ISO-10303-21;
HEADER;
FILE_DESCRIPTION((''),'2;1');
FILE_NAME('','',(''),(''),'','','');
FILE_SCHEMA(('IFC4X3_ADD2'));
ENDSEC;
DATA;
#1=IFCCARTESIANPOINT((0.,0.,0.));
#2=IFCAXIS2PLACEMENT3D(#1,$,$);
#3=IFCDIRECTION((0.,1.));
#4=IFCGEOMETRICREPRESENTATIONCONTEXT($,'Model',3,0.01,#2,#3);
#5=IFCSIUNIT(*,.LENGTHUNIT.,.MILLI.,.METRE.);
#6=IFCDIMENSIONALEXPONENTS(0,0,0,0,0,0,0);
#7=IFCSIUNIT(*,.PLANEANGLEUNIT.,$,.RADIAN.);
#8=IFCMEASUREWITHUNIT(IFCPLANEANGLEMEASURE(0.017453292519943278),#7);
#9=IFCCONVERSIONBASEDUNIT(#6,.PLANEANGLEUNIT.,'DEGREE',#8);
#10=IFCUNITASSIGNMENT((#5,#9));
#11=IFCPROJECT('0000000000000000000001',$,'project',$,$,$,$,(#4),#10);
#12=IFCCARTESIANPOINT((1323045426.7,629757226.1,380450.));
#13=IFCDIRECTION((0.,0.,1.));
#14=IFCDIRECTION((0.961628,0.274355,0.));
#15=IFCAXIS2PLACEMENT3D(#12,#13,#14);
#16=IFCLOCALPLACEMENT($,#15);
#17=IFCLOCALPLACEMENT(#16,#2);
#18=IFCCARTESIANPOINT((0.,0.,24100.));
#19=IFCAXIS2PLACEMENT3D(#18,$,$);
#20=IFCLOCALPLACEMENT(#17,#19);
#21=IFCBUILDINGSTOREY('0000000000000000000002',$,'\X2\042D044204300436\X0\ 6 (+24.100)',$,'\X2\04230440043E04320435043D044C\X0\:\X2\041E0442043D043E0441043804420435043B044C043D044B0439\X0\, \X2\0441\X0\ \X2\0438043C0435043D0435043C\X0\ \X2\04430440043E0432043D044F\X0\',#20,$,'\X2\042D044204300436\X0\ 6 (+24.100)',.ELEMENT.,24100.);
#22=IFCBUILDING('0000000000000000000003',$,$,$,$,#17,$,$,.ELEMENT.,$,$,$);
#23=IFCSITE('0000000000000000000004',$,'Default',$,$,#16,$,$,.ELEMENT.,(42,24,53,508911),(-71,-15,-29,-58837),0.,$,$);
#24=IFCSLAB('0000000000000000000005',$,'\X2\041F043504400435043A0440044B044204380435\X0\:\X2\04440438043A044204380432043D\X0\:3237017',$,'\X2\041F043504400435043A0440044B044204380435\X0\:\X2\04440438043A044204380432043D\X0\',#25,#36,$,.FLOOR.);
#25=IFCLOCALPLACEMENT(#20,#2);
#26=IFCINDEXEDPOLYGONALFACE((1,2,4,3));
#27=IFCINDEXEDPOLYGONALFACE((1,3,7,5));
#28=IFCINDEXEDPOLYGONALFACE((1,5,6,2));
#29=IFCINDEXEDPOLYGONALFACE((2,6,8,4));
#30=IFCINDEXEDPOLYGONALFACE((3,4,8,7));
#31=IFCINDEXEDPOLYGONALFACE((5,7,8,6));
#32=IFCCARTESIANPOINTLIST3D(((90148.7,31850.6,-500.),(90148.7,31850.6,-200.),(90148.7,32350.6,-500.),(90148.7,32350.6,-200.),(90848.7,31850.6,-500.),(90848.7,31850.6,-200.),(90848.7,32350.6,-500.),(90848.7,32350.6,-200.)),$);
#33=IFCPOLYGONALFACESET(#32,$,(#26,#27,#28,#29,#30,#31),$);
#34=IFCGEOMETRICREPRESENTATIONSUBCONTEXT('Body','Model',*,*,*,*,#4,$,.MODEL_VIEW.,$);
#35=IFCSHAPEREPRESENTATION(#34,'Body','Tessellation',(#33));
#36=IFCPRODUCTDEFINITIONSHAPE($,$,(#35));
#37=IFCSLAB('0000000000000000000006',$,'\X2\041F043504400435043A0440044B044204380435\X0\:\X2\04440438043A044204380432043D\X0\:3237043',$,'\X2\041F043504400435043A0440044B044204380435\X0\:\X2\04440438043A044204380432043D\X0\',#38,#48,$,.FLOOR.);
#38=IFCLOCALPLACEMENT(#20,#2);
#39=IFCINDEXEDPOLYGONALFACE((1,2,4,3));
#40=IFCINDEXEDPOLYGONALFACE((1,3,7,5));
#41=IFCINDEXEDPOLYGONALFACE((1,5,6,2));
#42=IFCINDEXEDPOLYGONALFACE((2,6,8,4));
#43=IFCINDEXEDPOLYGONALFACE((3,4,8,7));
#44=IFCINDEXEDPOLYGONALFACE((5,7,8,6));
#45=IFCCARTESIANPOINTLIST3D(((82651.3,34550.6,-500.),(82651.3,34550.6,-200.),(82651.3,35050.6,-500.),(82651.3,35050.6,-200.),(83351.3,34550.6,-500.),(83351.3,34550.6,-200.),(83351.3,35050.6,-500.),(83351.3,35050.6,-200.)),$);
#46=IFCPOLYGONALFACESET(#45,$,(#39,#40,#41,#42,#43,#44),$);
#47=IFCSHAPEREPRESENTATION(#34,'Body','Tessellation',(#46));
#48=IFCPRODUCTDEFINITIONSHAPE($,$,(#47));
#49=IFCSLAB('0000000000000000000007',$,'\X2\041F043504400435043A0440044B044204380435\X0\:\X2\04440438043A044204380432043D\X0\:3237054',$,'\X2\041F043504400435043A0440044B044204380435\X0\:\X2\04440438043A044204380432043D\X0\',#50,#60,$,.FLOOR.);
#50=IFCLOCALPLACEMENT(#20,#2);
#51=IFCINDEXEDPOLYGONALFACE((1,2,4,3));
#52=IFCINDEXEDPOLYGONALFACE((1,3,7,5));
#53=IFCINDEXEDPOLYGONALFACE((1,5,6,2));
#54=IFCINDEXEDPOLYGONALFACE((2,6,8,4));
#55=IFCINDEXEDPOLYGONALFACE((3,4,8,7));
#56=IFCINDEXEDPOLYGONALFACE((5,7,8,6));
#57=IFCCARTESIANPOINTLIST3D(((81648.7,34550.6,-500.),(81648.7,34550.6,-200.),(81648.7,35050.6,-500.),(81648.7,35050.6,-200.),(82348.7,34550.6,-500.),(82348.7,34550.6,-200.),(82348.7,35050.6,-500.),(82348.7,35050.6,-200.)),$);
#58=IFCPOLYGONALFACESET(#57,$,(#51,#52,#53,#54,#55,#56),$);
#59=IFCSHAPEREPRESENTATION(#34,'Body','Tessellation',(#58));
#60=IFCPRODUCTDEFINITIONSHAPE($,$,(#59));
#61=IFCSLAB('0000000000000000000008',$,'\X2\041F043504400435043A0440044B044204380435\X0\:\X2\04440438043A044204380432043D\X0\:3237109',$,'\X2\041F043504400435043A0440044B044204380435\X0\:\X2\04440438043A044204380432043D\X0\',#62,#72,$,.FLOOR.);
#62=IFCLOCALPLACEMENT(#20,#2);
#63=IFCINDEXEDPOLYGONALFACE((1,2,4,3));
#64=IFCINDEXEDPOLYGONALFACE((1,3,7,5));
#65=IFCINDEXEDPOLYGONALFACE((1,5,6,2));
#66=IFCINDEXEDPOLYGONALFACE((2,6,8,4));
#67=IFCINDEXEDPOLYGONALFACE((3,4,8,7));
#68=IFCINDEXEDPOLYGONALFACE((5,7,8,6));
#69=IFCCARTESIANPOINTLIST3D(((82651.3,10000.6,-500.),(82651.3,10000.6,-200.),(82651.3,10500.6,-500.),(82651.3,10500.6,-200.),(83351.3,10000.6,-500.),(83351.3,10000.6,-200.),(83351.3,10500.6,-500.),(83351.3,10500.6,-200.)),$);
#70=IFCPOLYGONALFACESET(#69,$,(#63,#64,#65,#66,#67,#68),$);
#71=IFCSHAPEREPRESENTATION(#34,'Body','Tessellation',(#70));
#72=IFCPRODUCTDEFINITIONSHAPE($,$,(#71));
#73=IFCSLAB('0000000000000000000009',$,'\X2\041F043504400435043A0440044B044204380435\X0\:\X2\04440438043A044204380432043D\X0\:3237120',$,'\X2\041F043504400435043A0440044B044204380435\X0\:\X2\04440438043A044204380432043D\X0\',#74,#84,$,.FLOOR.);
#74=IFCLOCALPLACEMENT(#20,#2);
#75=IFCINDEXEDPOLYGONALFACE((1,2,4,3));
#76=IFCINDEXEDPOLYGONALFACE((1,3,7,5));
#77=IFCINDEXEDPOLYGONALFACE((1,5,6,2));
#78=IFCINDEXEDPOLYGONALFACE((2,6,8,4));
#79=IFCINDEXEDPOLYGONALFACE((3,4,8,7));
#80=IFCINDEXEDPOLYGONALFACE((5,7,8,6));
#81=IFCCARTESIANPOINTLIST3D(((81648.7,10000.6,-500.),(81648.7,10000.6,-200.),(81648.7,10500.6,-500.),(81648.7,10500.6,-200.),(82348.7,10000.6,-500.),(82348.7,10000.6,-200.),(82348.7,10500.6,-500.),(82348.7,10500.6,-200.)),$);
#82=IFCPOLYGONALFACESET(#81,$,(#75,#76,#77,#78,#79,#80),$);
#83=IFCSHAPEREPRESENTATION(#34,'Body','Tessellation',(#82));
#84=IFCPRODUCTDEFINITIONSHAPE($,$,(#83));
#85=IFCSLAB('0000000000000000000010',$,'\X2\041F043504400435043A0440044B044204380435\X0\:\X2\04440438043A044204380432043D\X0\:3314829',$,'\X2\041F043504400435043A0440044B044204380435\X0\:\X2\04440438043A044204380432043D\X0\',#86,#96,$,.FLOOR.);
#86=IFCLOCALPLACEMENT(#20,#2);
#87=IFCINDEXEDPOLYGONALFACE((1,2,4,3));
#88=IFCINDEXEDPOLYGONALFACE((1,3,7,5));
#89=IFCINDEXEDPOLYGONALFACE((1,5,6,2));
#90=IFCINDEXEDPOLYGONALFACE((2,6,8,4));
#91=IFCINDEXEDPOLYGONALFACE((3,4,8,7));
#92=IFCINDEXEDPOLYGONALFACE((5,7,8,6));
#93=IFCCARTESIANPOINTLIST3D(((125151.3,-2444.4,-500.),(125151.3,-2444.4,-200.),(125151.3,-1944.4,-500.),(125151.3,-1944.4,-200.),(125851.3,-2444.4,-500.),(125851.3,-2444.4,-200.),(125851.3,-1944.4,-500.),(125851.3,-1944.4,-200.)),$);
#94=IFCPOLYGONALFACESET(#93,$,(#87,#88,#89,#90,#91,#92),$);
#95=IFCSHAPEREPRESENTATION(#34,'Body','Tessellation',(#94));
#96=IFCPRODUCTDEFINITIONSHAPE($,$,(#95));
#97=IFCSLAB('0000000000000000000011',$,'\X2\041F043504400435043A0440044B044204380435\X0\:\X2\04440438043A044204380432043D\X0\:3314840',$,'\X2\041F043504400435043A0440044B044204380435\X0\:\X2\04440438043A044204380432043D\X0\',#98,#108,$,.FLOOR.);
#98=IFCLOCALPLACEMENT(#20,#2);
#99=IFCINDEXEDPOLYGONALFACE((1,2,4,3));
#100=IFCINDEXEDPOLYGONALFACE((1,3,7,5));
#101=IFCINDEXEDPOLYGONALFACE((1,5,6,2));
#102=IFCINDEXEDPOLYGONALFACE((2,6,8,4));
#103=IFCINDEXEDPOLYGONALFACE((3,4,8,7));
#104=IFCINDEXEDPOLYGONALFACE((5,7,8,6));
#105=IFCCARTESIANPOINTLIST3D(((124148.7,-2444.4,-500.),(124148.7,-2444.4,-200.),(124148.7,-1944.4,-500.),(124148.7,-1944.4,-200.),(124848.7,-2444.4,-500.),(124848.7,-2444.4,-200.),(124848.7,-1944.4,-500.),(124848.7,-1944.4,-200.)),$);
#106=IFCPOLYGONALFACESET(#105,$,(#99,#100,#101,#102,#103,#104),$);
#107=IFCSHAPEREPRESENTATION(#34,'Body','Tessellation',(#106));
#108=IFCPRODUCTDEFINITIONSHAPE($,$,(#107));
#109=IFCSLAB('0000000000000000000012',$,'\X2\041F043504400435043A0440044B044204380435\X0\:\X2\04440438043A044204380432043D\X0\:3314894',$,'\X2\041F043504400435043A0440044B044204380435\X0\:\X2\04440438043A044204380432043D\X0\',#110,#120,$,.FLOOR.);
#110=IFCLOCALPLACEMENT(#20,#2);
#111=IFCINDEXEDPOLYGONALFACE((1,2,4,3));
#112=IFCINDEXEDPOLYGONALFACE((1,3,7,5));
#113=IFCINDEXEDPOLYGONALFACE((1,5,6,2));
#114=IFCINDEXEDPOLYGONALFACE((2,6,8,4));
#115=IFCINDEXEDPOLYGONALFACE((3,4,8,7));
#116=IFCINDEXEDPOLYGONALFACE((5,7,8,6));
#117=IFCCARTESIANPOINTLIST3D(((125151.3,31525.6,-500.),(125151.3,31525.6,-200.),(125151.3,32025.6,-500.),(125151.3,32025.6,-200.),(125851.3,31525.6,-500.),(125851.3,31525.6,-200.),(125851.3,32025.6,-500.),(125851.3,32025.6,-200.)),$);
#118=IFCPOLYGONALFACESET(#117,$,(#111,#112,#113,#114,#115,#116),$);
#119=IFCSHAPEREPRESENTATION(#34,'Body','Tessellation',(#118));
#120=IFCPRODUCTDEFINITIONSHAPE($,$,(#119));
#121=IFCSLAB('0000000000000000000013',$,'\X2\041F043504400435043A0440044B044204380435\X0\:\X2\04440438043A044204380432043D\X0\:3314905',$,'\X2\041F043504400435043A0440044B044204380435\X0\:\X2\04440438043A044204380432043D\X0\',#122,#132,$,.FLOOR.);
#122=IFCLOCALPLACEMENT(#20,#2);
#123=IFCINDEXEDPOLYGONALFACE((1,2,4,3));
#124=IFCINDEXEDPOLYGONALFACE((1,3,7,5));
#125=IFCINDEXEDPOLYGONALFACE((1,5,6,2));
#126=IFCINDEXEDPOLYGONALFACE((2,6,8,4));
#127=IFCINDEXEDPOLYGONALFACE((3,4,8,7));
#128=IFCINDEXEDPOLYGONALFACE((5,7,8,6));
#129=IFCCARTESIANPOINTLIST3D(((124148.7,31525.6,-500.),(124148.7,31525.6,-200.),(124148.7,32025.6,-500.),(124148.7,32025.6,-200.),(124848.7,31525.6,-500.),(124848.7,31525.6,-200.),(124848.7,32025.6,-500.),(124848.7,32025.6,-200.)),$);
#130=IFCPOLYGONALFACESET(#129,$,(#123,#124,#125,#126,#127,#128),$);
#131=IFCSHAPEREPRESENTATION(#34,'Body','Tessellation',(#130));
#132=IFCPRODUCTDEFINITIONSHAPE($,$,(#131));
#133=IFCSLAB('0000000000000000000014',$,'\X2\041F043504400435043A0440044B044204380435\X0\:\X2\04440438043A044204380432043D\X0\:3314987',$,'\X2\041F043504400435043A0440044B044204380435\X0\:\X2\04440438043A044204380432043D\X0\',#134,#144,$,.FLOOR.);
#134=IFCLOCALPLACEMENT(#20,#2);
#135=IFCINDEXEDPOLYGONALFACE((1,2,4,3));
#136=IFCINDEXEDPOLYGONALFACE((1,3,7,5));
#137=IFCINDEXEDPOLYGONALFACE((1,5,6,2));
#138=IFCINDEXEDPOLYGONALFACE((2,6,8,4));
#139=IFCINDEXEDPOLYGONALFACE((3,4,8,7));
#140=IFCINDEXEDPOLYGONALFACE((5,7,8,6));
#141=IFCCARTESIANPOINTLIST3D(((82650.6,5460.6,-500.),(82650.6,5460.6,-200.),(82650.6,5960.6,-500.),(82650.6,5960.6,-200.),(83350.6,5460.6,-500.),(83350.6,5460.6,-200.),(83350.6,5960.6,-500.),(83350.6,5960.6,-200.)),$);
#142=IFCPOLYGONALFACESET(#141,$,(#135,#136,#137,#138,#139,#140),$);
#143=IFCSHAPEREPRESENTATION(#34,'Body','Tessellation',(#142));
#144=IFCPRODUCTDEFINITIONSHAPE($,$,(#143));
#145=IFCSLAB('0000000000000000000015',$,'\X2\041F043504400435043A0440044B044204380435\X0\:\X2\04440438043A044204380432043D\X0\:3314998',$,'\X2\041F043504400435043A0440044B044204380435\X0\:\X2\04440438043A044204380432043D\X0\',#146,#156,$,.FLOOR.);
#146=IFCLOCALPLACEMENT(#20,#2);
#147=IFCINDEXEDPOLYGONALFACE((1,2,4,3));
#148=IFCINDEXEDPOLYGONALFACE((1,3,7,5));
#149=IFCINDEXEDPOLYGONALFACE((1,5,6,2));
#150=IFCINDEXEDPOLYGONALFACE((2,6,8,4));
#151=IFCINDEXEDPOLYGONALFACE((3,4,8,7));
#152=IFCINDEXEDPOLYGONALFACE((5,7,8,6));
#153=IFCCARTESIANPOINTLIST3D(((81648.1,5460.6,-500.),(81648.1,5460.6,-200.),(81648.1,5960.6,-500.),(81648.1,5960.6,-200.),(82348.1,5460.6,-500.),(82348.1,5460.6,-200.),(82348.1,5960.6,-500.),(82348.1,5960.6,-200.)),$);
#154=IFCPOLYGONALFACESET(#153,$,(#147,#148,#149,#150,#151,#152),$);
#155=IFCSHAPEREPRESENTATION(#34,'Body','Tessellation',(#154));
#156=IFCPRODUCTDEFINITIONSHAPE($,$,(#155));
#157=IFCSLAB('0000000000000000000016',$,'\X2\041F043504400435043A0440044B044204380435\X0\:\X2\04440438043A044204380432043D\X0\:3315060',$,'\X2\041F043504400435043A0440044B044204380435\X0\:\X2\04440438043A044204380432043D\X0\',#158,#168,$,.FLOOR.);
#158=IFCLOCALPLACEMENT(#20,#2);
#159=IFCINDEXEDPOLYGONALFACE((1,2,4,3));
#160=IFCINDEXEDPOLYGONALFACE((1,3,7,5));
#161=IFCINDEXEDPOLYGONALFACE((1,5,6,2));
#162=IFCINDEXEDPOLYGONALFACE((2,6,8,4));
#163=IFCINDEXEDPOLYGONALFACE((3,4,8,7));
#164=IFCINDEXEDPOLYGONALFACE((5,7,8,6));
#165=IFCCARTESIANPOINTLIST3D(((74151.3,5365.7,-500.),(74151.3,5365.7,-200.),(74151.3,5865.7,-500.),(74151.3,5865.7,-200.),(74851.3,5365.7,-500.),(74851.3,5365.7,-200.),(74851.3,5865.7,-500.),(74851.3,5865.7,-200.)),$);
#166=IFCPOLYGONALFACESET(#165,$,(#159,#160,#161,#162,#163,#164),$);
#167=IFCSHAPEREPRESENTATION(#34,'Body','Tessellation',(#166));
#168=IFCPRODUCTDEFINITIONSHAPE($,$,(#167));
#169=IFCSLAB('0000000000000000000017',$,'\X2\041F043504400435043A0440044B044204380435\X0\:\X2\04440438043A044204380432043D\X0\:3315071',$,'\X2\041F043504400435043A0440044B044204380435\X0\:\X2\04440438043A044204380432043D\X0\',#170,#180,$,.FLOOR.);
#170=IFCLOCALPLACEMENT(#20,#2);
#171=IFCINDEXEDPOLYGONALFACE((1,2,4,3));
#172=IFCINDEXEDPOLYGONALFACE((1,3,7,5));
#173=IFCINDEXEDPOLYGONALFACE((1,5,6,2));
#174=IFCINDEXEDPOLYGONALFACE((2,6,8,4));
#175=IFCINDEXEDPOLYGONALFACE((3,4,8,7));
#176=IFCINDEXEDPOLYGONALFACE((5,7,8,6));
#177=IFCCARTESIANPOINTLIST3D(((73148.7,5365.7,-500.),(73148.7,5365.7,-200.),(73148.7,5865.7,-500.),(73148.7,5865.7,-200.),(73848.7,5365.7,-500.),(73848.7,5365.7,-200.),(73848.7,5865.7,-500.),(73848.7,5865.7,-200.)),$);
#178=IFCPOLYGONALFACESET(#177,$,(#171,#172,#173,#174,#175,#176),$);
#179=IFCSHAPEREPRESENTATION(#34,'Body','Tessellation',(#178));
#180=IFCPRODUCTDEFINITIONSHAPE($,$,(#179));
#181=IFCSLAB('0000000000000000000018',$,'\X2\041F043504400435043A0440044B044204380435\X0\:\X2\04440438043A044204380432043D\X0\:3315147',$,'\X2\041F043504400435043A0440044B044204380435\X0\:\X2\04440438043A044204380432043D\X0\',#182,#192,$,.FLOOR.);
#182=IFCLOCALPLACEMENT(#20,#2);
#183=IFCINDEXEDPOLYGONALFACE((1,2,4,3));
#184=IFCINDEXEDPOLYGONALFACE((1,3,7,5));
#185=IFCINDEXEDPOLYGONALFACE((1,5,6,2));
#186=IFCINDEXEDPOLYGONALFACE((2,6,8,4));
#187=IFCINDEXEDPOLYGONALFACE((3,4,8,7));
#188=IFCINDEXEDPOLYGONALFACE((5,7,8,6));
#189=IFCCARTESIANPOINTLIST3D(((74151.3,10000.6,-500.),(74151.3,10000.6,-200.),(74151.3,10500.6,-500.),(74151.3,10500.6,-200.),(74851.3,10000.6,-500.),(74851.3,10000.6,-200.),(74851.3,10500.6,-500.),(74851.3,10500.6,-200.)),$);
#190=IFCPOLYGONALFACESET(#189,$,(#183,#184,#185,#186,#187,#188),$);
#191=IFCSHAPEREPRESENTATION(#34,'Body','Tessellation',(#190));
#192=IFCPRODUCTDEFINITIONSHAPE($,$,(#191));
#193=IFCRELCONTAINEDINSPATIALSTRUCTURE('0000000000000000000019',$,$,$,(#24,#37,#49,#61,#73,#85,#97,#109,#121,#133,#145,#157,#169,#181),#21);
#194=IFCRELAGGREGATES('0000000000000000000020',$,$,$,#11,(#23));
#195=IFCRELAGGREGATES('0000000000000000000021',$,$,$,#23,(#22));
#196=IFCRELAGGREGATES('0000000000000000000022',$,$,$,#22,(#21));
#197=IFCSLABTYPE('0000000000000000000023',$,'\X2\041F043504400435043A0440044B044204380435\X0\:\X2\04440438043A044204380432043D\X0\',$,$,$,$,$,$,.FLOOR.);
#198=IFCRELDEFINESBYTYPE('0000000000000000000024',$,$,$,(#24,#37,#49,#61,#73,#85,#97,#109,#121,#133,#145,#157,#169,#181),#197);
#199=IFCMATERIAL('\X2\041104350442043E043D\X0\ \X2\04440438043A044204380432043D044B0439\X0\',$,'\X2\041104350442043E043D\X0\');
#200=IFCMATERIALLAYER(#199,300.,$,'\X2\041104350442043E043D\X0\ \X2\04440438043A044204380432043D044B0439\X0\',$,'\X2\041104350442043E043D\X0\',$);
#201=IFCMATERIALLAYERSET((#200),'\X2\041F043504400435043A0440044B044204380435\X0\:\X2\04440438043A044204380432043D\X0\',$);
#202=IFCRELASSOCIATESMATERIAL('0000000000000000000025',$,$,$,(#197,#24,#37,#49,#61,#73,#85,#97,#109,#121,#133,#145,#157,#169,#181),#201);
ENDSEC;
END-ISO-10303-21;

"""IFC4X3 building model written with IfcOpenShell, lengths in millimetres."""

from ifc_helpers import new_model, entity, si_unit, converted_unit, direction, frame, frame_2d, origin, origin_2d_with_axis, place, context, subcontext, project, spatial, rectangle, extrude, material, layer, layer_set, layer_usage, type_object, element, save


model = new_model("IFC4X3")

# Units and contexts
model_context = context("Model", 3, precision=0.01, world=origin(), true_north=direction((0.0, 1.0)))
body_context = subcontext(model_context, "Body", "Model", "MODEL_VIEW")
ifc_project = project(units=[si_unit("LENGTHUNIT", "METRE", prefix="MILLI"), converted_unit("PLANEANGLEUNIT", "DEGREE", entity("IfcPlaneAngleMeasure", 0.017453292519943278), si_unit("PLANEANGLEUNIT", "RADIAN"), dimensions=[0, 0, 0, 0, 0, 0, 0])], contexts=[model_context])

# Site, building, storey
site_placement = place(None, frame((1323045426.7, 629757226.1, 380450.0), z_axis=(0.0, 0.0, 1.0), x_axis=(0.961628, 0.274355, 0.0)))
site = spatial("IfcSite", under=ifc_project, at=site_placement, Name="Default", CompositionType="ELEMENT", RefLatitude=(42, 24, 53, 508911), RefLongitude=(-71, -15, -29, -58837), RefElevation=0.0)
building_placement = place(site_placement, origin())
building = spatial("IfcBuilding", under=site, at=building_placement, CompositionType="ELEMENT")
storey_placement = place(building_placement, frame((0.0, 0.0, 24100.0)))
storey = spatial("IfcBuildingStorey", under=building, at=storey_placement, Name="Этаж 6 (+24.100)", ObjectType="Уровень:Относительный, с именем уровня", LongName="Этаж 6 (+24.100)", CompositionType="ELEMENT", Elevation=24100.0)

# Slabs
ifc_material = material(Name="Бетон фиктивный", Category="Бетон")
ifc_layer = layer(ifc_material, 300.0, Name="Бетон фиктивный", Category="Бетон")
ifc_layer_set = layer_set([ifc_layer], Name="Перекрытие:фиктивн")
ifc_layer_usage_1 = layer_usage(ifc_layer_set, "AXIS3", "POSITIVE", 0.0)
slab_type = type_object("IfcSlabType", Name="Перекрытие:фиктивн", PredefinedType="FLOOR", material=ifc_layer_set)
slab_1_placement = place(storey_placement, origin())
element("IfcSlab", 1, at=slab_1_placement, inside=storey, type_object=slab_type, material=ifc_layer_usage_1, Name="Перекрытие:фиктивн:3237017", ObjectType="Перекрытие:фиктивн", PredefinedType="FLOOR", context=body_context, shape_type="SweptSolid", body=[
    extrude(rectangle(XDim=500.0, YDim=700.0, at=frame_2d((0.0, 0.0), x_axis=(1.0, 0.0))), frame((90498.7, 32100.6, -200.0), z_axis=(0.0, 0.0, -1.0), x_axis=(0.0, 1.0, 0.0)), (0.0, 0.0, 1.0), 300.0),
])
ifc_layer_usage_2 = layer_usage(ifc_layer_set, "AXIS3", "POSITIVE", 0.0)
slab_2_placement = place(storey_placement, origin())
element("IfcSlab", 2, at=slab_2_placement, inside=storey, type_object=slab_type, material=ifc_layer_usage_2, Name="Перекрытие:фиктивн:3237043", ObjectType="Перекрытие:фиктивн", PredefinedType="FLOOR", context=body_context, shape_type="SweptSolid", body=[
    extrude(rectangle(XDim=500.0, YDim=700.0, at=frame_2d((0.0, 0.0), x_axis=(1.0, 0.0))), frame((83001.3, 34800.6, -200.0), z_axis=(0.0, 0.0, -1.0), x_axis=(0.0, 1.0, 0.0)), (0.0, 0.0, 1.0), 300.0),
])
ifc_layer_usage_3 = layer_usage(ifc_layer_set, "AXIS3", "POSITIVE", 0.0)
slab_3_placement = place(storey_placement, origin())
element("IfcSlab", 3, at=slab_3_placement, inside=storey, type_object=slab_type, material=ifc_layer_usage_3, Name="Перекрытие:фиктивн:3237054", ObjectType="Перекрытие:фиктивн", PredefinedType="FLOOR", context=body_context, shape_type="SweptSolid", body=[
    extrude(rectangle(XDim=500.0, YDim=700.0, at=frame_2d((0.0, 0.0), x_axis=(1.0, 0.0))), frame((81998.7, 34800.6, -200.0), z_axis=(0.0, 0.0, -1.0), x_axis=(0.0, 1.0, 0.0)), (0.0, 0.0, 1.0), 300.0),
])
ifc_layer_usage_4 = layer_usage(ifc_layer_set, "AXIS3", "POSITIVE", 0.0)
slab_4_placement = place(storey_placement, origin())
element("IfcSlab", 4, at=slab_4_placement, inside=storey, type_object=slab_type, material=ifc_layer_usage_4, Name="Перекрытие:фиктивн:3237109", ObjectType="Перекрытие:фиктивн", PredefinedType="FLOOR", context=body_context, shape_type="SweptSolid", body=[
    extrude(rectangle(XDim=500.0, YDim=700.0, at=frame_2d((0.0, 0.0), x_axis=(1.0, 0.0))), frame((83001.3, 10250.6, -200.0), z_axis=(0.0, 0.0, -1.0), x_axis=(0.0, 1.0, 0.0)), (0.0, 0.0, 1.0), 300.0),
])
ifc_layer_usage_5 = layer_usage(ifc_layer_set, "AXIS3", "POSITIVE", 0.0)
slab_5_placement = place(storey_placement, origin())
element("IfcSlab", 5, at=slab_5_placement, inside=storey, type_object=slab_type, material=ifc_layer_usage_5, Name="Перекрытие:фиктивн:3237120", ObjectType="Перекрытие:фиктивн", PredefinedType="FLOOR", context=body_context, shape_type="SweptSolid", body=[
    extrude(rectangle(XDim=500.0, YDim=700.0, at=frame_2d((0.0, 0.0), x_axis=(1.0, 0.0))), frame((81998.7, 10250.6, -200.0), z_axis=(0.0, 0.0, -1.0), x_axis=(0.0, 1.0, 0.0)), (0.0, 0.0, 1.0), 300.0),
])
ifc_layer_usage_6 = layer_usage(ifc_layer_set, "AXIS3", "POSITIVE", 0.0)
slab_6_placement = place(storey_placement, origin())
element("IfcSlab", 6, at=slab_6_placement, inside=storey, type_object=slab_type, material=ifc_layer_usage_6, Name="Перекрытие:фиктивн:3314829", ObjectType="Перекрытие:фиктивн", PredefinedType="FLOOR", context=body_context, shape_type="SweptSolid", body=[
    extrude(rectangle(XDim=500.0, YDim=700.0, at=frame_2d((0.0, 0.0), x_axis=(1.0, 0.0))), frame((125501.3, -2194.4, -200.0), z_axis=(0.0, 0.0, -1.0), x_axis=(0.0, 1.0, 0.0)), (0.0, 0.0, 1.0), 300.0),
])
ifc_layer_usage_7 = layer_usage(ifc_layer_set, "AXIS3", "POSITIVE", 0.0)
slab_7_placement = place(storey_placement, origin())
element("IfcSlab", 7, at=slab_7_placement, inside=storey, type_object=slab_type, material=ifc_layer_usage_7, Name="Перекрытие:фиктивн:3314840", ObjectType="Перекрытие:фиктивн", PredefinedType="FLOOR", context=body_context, shape_type="SweptSolid", body=[
    extrude(rectangle(XDim=500.0, YDim=700.0, at=frame_2d((0.0, 0.0), x_axis=(1.0, 0.0))), frame((124498.7, -2194.4, -200.0), z_axis=(0.0, 0.0, -1.0), x_axis=(0.0, 1.0, 0.0)), (0.0, 0.0, 1.0), 300.0),
])
ifc_layer_usage_8 = layer_usage(ifc_layer_set, "AXIS3", "POSITIVE", 0.0)
slab_8_placement = place(storey_placement, origin())
element("IfcSlab", 8, at=slab_8_placement, inside=storey, type_object=slab_type, material=ifc_layer_usage_8, Name="Перекрытие:фиктивн:3314894", ObjectType="Перекрытие:фиктивн", PredefinedType="FLOOR", context=body_context, shape_type="SweptSolid", body=[
    extrude(rectangle(XDim=500.0, YDim=700.0, at=frame_2d((0.0, 0.0), x_axis=(1.0, 0.0))), frame((125501.3, 31775.6, -200.0), z_axis=(0.0, 0.0, -1.0), x_axis=(0.0, 1.0, 0.0)), (0.0, 0.0, 1.0), 300.0),
])
ifc_layer_usage_9 = layer_usage(ifc_layer_set, "AXIS3", "POSITIVE", 0.0)
slab_9_placement = place(storey_placement, origin())
element("IfcSlab", 9, at=slab_9_placement, inside=storey, type_object=slab_type, material=ifc_layer_usage_9, Name="Перекрытие:фиктивн:3314905", ObjectType="Перекрытие:фиктивн", PredefinedType="FLOOR", context=body_context, shape_type="SweptSolid", body=[
    extrude(rectangle(XDim=500.0, YDim=700.0, at=frame_2d((0.0, 0.0), x_axis=(1.0, 0.0))), frame((124498.7, 31775.6, -200.0), z_axis=(0.0, 0.0, -1.0), x_axis=(0.0, 1.0, 0.0)), (0.0, 0.0, 1.0), 300.0),
])
ifc_layer_usage_10 = layer_usage(ifc_layer_set, "AXIS3", "POSITIVE", 0.0)
slab_10_placement = place(storey_placement, origin())
element("IfcSlab", 10, at=slab_10_placement, inside=storey, type_object=slab_type, material=ifc_layer_usage_10, Name="Перекрытие:фиктивн:3314987", ObjectType="Перекрытие:фиктивн", PredefinedType="FLOOR", context=body_context, shape_type="SweptSolid", body=[
    extrude(rectangle(XDim=500.0, YDim=700.0, at=frame_2d((0.0, 0.0), x_axis=(1.0, 0.0))), frame((83000.6, 5710.6, -200.0), z_axis=(0.0, 0.0, -1.0), x_axis=(0.0, 1.0, 0.0)), (0.0, 0.0, 1.0), 300.0),
])
ifc_layer_usage_11 = layer_usage(ifc_layer_set, "AXIS3", "POSITIVE", 0.0)
slab_11_placement = place(storey_placement, origin())
element("IfcSlab", 11, at=slab_11_placement, inside=storey, type_object=slab_type, material=ifc_layer_usage_11, Name="Перекрытие:фиктивн:3314998", ObjectType="Перекрытие:фиктивн", PredefinedType="FLOOR", context=body_context, shape_type="SweptSolid", body=[
    extrude(rectangle(XDim=500.0, YDim=700.0, at=frame_2d((0.0, 0.0), x_axis=(1.0, 0.0))), frame((81998.1, 5710.6, -200.0), z_axis=(0.0, 0.0, -1.0), x_axis=(0.0, 1.0, 0.0)), (0.0, 0.0, 1.0), 300.0),
])
ifc_layer_usage_12 = layer_usage(ifc_layer_set, "AXIS3", "POSITIVE", 0.0)
slab_12_placement = place(storey_placement, origin())
element("IfcSlab", 12, at=slab_12_placement, inside=storey, type_object=slab_type, material=ifc_layer_usage_12, Name="Перекрытие:фиктивн:3315060", ObjectType="Перекрытие:фиктивн", PredefinedType="FLOOR", context=body_context, shape_type="SweptSolid", body=[
    extrude(rectangle(XDim=500.0, YDim=700.0, at=frame_2d((0.0, 0.0), x_axis=(1.0, 0.0))), frame((74501.3, 5615.7, -200.0), z_axis=(0.0, 0.0, -1.0), x_axis=(0.0, 1.0, 0.0)), (0.0, 0.0, 1.0), 300.0),
])
ifc_layer_usage_13 = layer_usage(ifc_layer_set, "AXIS3", "POSITIVE", 0.0)
slab_13_placement = place(storey_placement, origin())
element("IfcSlab", 13, at=slab_13_placement, inside=storey, type_object=slab_type, material=ifc_layer_usage_13, Name="Перекрытие:фиктивн:3315071", ObjectType="Перекрытие:фиктивн", PredefinedType="FLOOR", context=body_context, shape_type="SweptSolid", body=[
    extrude(rectangle(XDim=500.0, YDim=700.0, at=frame_2d((0.0, 0.0), x_axis=(1.0, 0.0))), frame((73498.7, 5615.7, -200.0), z_axis=(0.0, 0.0, -1.0), x_axis=(0.0, 1.0, 0.0)), (0.0, 0.0, 1.0), 300.0),
])
ifc_layer_usage_14 = layer_usage(ifc_layer_set, "AXIS3", "POSITIVE", 0.0)
slab_14_placement = place(storey_placement, origin())
element("IfcSlab", 14, at=slab_14_placement, inside=storey, type_object=slab_type, material=ifc_layer_usage_14, Name="Перекрытие:фиктивн:3315147", ObjectType="Перекрытие:фиктивн", PredefinedType="FLOOR", context=body_context, shape_type="SweptSolid", body=[
    extrude(rectangle(XDim=500.0, YDim=700.0, at=origin_2d_with_axis()), frame((74501.3, 10250.6, -200.0), z_axis=(0.0, 0.0, -1.0), x_axis=(0.0, 1.0, 0.0)), (0.0, 0.0, 1.0), 300.0),
])

save(model, "model.ifc")
